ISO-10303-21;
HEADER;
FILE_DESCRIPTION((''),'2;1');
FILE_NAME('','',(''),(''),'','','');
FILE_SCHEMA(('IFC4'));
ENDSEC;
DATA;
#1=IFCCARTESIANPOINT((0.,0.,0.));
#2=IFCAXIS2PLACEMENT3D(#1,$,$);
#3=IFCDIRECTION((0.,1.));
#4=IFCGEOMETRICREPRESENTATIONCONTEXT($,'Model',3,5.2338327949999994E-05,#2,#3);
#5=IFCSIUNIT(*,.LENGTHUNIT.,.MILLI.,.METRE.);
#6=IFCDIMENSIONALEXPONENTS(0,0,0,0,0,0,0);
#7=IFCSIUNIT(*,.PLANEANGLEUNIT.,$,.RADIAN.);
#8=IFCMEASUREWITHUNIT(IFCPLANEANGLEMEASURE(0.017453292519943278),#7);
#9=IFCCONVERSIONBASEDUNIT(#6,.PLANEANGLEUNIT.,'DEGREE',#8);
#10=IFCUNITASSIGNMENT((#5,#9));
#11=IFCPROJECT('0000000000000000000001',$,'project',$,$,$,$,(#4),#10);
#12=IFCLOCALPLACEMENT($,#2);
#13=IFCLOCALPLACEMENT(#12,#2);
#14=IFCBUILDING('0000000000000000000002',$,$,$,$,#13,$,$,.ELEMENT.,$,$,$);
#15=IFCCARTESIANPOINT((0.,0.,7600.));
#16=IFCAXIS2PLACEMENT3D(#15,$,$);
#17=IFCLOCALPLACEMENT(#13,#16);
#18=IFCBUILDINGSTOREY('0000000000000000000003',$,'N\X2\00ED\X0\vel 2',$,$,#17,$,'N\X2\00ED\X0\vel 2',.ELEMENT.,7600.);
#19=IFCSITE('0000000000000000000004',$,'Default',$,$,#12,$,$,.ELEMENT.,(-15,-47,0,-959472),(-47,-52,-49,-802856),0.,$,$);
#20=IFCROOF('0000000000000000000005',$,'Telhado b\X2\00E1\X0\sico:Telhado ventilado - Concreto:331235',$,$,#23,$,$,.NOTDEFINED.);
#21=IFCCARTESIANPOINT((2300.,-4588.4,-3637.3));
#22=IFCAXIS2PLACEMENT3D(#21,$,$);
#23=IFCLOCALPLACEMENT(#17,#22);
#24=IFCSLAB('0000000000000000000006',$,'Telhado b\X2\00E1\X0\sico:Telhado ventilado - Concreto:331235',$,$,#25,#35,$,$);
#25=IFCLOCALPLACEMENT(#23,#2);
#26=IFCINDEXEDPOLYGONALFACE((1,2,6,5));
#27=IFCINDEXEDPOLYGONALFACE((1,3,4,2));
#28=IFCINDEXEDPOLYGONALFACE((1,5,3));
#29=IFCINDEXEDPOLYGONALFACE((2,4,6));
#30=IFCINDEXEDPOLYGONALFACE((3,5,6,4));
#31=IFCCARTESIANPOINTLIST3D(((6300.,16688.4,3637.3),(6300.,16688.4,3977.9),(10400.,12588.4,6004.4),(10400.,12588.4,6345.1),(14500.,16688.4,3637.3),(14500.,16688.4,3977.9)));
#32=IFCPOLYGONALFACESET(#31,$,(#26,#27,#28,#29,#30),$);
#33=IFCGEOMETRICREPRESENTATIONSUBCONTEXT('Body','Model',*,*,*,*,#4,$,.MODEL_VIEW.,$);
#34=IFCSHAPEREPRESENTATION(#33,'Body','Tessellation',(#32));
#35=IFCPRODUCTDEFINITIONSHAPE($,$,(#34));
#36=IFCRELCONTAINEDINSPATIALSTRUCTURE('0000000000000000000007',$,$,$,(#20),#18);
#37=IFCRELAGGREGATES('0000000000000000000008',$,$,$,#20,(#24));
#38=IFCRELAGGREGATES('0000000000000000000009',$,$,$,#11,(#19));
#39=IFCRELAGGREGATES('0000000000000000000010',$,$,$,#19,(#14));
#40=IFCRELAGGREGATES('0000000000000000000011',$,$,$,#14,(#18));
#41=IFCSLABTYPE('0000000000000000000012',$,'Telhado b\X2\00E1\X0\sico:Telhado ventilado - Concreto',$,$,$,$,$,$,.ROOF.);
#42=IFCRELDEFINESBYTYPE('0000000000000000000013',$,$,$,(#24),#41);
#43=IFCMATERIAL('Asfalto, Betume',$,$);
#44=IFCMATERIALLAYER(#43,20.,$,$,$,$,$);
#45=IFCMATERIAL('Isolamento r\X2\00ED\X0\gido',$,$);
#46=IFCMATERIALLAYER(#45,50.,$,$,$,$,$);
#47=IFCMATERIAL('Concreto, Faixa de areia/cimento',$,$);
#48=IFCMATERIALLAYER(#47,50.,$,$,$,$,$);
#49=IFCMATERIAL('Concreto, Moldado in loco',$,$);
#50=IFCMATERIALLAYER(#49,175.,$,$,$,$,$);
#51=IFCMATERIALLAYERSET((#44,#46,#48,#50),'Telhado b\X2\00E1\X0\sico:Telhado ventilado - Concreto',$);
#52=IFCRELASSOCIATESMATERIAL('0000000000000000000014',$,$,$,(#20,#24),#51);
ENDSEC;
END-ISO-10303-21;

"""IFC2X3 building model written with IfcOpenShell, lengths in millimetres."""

from ifc_helpers import new_model, entity, si_unit, converted_unit, direction, frame, origin, place, context, subcontext, project, spatial, polyline, outline, extrude, material, layer, layer_set, type_object, element, aggregate, save


model = new_model("IFC2X3")

# Units and contexts
model_context = context("Model", 3, precision=5.2338327949999994e-05, world=origin(), true_north=direction((0.0, 1.0)))
body_context = subcontext(model_context, "Body", "Model", "MODEL_VIEW")
ifc_project = project(units=[si_unit("LENGTHUNIT", "METRE", prefix="MILLI"), converted_unit("PLANEANGLEUNIT", "DEGREE", entity("IfcPlaneAngleMeasure", 0.017453292519943278), si_unit("PLANEANGLEUNIT", "RADIAN"), dimensions=[0, 0, 0, 0, 0, 0, 0])], contexts=[model_context])

# Site, building, storey
site_placement = place(None, origin())
site = spatial("IfcSite", under=ifc_project, at=site_placement, Name="Default", CompositionType="ELEMENT", RefLatitude=(-15, -47, 0, -959472), RefLongitude=(-47, -52, -49, -802856), RefElevation=0.0)
building_placement = place(site_placement, origin())
building = spatial("IfcBuilding", under=site, at=building_placement, CompositionType="ELEMENT")
storey_placement = place(building_placement, frame((0.0, 0.0, 7600.0)))
storey = spatial("IfcBuildingStorey", under=building, at=storey_placement, Name="Nível 2", LongName="Nível 2", CompositionType="ELEMENT", Elevation=7600.0)

# Roof, slab
ifc_material_1 = material(Name="Asfalto, Betume")
ifc_layer_1 = layer(ifc_material_1, 20.0)
ifc_material_2 = material(Name="Isolamento rígido")
ifc_layer_2 = layer(ifc_material_2, 50.0)
ifc_material_3 = material(Name="Concreto, Faixa de areia/cimento")
ifc_layer_3 = layer(ifc_material_3, 50.0)
ifc_material_4 = material(Name="Concreto, Moldado in loco")
ifc_layer_4 = layer(ifc_material_4, 175.0)
ifc_layer_set = layer_set([ifc_layer_1, ifc_layer_2, ifc_layer_3, ifc_layer_4], Name="Telhado básico:Telhado ventilado - Concreto")
roof_placement = place(storey_placement, frame((2300.0, -4588.4, -3637.3)))
roof = element("IfcRoof", 1, at=roof_placement, inside=storey, material=ifc_layer_set, Name="Telhado básico:Telhado ventilado - Concreto:331235", ShapeType="NOTDEFINED")
slab_type = type_object("IfcSlabType", Name="Telhado básico:Telhado ventilado - Concreto", PredefinedType="ROOF")
slab_1_placement = place(roof_placement, origin())
slab_1 = element("IfcSlab", 2, at=slab_1_placement, type_object=slab_type, material=ifc_layer_set, Name="Telhado básico:Telhado ventilado - Concreto:331235", context=body_context, shape_type="SweptSolid", body=[
    extrude(outline(polyline([(4100.0, 2367.1), (-4100.0, 2367.1), (0.0, -2367.1), (4100.0, 2367.1)])), frame((10400.0, 14638.4, 4820.9), z_axis=(0.0, 0.5, 0.866025), x_axis=(1.0, 0.0, 0.0)), (0.0, -0.5, 0.866025), 340.6),
])
aggregate(roof, [slab_1])

save(model, "model.ifc")
